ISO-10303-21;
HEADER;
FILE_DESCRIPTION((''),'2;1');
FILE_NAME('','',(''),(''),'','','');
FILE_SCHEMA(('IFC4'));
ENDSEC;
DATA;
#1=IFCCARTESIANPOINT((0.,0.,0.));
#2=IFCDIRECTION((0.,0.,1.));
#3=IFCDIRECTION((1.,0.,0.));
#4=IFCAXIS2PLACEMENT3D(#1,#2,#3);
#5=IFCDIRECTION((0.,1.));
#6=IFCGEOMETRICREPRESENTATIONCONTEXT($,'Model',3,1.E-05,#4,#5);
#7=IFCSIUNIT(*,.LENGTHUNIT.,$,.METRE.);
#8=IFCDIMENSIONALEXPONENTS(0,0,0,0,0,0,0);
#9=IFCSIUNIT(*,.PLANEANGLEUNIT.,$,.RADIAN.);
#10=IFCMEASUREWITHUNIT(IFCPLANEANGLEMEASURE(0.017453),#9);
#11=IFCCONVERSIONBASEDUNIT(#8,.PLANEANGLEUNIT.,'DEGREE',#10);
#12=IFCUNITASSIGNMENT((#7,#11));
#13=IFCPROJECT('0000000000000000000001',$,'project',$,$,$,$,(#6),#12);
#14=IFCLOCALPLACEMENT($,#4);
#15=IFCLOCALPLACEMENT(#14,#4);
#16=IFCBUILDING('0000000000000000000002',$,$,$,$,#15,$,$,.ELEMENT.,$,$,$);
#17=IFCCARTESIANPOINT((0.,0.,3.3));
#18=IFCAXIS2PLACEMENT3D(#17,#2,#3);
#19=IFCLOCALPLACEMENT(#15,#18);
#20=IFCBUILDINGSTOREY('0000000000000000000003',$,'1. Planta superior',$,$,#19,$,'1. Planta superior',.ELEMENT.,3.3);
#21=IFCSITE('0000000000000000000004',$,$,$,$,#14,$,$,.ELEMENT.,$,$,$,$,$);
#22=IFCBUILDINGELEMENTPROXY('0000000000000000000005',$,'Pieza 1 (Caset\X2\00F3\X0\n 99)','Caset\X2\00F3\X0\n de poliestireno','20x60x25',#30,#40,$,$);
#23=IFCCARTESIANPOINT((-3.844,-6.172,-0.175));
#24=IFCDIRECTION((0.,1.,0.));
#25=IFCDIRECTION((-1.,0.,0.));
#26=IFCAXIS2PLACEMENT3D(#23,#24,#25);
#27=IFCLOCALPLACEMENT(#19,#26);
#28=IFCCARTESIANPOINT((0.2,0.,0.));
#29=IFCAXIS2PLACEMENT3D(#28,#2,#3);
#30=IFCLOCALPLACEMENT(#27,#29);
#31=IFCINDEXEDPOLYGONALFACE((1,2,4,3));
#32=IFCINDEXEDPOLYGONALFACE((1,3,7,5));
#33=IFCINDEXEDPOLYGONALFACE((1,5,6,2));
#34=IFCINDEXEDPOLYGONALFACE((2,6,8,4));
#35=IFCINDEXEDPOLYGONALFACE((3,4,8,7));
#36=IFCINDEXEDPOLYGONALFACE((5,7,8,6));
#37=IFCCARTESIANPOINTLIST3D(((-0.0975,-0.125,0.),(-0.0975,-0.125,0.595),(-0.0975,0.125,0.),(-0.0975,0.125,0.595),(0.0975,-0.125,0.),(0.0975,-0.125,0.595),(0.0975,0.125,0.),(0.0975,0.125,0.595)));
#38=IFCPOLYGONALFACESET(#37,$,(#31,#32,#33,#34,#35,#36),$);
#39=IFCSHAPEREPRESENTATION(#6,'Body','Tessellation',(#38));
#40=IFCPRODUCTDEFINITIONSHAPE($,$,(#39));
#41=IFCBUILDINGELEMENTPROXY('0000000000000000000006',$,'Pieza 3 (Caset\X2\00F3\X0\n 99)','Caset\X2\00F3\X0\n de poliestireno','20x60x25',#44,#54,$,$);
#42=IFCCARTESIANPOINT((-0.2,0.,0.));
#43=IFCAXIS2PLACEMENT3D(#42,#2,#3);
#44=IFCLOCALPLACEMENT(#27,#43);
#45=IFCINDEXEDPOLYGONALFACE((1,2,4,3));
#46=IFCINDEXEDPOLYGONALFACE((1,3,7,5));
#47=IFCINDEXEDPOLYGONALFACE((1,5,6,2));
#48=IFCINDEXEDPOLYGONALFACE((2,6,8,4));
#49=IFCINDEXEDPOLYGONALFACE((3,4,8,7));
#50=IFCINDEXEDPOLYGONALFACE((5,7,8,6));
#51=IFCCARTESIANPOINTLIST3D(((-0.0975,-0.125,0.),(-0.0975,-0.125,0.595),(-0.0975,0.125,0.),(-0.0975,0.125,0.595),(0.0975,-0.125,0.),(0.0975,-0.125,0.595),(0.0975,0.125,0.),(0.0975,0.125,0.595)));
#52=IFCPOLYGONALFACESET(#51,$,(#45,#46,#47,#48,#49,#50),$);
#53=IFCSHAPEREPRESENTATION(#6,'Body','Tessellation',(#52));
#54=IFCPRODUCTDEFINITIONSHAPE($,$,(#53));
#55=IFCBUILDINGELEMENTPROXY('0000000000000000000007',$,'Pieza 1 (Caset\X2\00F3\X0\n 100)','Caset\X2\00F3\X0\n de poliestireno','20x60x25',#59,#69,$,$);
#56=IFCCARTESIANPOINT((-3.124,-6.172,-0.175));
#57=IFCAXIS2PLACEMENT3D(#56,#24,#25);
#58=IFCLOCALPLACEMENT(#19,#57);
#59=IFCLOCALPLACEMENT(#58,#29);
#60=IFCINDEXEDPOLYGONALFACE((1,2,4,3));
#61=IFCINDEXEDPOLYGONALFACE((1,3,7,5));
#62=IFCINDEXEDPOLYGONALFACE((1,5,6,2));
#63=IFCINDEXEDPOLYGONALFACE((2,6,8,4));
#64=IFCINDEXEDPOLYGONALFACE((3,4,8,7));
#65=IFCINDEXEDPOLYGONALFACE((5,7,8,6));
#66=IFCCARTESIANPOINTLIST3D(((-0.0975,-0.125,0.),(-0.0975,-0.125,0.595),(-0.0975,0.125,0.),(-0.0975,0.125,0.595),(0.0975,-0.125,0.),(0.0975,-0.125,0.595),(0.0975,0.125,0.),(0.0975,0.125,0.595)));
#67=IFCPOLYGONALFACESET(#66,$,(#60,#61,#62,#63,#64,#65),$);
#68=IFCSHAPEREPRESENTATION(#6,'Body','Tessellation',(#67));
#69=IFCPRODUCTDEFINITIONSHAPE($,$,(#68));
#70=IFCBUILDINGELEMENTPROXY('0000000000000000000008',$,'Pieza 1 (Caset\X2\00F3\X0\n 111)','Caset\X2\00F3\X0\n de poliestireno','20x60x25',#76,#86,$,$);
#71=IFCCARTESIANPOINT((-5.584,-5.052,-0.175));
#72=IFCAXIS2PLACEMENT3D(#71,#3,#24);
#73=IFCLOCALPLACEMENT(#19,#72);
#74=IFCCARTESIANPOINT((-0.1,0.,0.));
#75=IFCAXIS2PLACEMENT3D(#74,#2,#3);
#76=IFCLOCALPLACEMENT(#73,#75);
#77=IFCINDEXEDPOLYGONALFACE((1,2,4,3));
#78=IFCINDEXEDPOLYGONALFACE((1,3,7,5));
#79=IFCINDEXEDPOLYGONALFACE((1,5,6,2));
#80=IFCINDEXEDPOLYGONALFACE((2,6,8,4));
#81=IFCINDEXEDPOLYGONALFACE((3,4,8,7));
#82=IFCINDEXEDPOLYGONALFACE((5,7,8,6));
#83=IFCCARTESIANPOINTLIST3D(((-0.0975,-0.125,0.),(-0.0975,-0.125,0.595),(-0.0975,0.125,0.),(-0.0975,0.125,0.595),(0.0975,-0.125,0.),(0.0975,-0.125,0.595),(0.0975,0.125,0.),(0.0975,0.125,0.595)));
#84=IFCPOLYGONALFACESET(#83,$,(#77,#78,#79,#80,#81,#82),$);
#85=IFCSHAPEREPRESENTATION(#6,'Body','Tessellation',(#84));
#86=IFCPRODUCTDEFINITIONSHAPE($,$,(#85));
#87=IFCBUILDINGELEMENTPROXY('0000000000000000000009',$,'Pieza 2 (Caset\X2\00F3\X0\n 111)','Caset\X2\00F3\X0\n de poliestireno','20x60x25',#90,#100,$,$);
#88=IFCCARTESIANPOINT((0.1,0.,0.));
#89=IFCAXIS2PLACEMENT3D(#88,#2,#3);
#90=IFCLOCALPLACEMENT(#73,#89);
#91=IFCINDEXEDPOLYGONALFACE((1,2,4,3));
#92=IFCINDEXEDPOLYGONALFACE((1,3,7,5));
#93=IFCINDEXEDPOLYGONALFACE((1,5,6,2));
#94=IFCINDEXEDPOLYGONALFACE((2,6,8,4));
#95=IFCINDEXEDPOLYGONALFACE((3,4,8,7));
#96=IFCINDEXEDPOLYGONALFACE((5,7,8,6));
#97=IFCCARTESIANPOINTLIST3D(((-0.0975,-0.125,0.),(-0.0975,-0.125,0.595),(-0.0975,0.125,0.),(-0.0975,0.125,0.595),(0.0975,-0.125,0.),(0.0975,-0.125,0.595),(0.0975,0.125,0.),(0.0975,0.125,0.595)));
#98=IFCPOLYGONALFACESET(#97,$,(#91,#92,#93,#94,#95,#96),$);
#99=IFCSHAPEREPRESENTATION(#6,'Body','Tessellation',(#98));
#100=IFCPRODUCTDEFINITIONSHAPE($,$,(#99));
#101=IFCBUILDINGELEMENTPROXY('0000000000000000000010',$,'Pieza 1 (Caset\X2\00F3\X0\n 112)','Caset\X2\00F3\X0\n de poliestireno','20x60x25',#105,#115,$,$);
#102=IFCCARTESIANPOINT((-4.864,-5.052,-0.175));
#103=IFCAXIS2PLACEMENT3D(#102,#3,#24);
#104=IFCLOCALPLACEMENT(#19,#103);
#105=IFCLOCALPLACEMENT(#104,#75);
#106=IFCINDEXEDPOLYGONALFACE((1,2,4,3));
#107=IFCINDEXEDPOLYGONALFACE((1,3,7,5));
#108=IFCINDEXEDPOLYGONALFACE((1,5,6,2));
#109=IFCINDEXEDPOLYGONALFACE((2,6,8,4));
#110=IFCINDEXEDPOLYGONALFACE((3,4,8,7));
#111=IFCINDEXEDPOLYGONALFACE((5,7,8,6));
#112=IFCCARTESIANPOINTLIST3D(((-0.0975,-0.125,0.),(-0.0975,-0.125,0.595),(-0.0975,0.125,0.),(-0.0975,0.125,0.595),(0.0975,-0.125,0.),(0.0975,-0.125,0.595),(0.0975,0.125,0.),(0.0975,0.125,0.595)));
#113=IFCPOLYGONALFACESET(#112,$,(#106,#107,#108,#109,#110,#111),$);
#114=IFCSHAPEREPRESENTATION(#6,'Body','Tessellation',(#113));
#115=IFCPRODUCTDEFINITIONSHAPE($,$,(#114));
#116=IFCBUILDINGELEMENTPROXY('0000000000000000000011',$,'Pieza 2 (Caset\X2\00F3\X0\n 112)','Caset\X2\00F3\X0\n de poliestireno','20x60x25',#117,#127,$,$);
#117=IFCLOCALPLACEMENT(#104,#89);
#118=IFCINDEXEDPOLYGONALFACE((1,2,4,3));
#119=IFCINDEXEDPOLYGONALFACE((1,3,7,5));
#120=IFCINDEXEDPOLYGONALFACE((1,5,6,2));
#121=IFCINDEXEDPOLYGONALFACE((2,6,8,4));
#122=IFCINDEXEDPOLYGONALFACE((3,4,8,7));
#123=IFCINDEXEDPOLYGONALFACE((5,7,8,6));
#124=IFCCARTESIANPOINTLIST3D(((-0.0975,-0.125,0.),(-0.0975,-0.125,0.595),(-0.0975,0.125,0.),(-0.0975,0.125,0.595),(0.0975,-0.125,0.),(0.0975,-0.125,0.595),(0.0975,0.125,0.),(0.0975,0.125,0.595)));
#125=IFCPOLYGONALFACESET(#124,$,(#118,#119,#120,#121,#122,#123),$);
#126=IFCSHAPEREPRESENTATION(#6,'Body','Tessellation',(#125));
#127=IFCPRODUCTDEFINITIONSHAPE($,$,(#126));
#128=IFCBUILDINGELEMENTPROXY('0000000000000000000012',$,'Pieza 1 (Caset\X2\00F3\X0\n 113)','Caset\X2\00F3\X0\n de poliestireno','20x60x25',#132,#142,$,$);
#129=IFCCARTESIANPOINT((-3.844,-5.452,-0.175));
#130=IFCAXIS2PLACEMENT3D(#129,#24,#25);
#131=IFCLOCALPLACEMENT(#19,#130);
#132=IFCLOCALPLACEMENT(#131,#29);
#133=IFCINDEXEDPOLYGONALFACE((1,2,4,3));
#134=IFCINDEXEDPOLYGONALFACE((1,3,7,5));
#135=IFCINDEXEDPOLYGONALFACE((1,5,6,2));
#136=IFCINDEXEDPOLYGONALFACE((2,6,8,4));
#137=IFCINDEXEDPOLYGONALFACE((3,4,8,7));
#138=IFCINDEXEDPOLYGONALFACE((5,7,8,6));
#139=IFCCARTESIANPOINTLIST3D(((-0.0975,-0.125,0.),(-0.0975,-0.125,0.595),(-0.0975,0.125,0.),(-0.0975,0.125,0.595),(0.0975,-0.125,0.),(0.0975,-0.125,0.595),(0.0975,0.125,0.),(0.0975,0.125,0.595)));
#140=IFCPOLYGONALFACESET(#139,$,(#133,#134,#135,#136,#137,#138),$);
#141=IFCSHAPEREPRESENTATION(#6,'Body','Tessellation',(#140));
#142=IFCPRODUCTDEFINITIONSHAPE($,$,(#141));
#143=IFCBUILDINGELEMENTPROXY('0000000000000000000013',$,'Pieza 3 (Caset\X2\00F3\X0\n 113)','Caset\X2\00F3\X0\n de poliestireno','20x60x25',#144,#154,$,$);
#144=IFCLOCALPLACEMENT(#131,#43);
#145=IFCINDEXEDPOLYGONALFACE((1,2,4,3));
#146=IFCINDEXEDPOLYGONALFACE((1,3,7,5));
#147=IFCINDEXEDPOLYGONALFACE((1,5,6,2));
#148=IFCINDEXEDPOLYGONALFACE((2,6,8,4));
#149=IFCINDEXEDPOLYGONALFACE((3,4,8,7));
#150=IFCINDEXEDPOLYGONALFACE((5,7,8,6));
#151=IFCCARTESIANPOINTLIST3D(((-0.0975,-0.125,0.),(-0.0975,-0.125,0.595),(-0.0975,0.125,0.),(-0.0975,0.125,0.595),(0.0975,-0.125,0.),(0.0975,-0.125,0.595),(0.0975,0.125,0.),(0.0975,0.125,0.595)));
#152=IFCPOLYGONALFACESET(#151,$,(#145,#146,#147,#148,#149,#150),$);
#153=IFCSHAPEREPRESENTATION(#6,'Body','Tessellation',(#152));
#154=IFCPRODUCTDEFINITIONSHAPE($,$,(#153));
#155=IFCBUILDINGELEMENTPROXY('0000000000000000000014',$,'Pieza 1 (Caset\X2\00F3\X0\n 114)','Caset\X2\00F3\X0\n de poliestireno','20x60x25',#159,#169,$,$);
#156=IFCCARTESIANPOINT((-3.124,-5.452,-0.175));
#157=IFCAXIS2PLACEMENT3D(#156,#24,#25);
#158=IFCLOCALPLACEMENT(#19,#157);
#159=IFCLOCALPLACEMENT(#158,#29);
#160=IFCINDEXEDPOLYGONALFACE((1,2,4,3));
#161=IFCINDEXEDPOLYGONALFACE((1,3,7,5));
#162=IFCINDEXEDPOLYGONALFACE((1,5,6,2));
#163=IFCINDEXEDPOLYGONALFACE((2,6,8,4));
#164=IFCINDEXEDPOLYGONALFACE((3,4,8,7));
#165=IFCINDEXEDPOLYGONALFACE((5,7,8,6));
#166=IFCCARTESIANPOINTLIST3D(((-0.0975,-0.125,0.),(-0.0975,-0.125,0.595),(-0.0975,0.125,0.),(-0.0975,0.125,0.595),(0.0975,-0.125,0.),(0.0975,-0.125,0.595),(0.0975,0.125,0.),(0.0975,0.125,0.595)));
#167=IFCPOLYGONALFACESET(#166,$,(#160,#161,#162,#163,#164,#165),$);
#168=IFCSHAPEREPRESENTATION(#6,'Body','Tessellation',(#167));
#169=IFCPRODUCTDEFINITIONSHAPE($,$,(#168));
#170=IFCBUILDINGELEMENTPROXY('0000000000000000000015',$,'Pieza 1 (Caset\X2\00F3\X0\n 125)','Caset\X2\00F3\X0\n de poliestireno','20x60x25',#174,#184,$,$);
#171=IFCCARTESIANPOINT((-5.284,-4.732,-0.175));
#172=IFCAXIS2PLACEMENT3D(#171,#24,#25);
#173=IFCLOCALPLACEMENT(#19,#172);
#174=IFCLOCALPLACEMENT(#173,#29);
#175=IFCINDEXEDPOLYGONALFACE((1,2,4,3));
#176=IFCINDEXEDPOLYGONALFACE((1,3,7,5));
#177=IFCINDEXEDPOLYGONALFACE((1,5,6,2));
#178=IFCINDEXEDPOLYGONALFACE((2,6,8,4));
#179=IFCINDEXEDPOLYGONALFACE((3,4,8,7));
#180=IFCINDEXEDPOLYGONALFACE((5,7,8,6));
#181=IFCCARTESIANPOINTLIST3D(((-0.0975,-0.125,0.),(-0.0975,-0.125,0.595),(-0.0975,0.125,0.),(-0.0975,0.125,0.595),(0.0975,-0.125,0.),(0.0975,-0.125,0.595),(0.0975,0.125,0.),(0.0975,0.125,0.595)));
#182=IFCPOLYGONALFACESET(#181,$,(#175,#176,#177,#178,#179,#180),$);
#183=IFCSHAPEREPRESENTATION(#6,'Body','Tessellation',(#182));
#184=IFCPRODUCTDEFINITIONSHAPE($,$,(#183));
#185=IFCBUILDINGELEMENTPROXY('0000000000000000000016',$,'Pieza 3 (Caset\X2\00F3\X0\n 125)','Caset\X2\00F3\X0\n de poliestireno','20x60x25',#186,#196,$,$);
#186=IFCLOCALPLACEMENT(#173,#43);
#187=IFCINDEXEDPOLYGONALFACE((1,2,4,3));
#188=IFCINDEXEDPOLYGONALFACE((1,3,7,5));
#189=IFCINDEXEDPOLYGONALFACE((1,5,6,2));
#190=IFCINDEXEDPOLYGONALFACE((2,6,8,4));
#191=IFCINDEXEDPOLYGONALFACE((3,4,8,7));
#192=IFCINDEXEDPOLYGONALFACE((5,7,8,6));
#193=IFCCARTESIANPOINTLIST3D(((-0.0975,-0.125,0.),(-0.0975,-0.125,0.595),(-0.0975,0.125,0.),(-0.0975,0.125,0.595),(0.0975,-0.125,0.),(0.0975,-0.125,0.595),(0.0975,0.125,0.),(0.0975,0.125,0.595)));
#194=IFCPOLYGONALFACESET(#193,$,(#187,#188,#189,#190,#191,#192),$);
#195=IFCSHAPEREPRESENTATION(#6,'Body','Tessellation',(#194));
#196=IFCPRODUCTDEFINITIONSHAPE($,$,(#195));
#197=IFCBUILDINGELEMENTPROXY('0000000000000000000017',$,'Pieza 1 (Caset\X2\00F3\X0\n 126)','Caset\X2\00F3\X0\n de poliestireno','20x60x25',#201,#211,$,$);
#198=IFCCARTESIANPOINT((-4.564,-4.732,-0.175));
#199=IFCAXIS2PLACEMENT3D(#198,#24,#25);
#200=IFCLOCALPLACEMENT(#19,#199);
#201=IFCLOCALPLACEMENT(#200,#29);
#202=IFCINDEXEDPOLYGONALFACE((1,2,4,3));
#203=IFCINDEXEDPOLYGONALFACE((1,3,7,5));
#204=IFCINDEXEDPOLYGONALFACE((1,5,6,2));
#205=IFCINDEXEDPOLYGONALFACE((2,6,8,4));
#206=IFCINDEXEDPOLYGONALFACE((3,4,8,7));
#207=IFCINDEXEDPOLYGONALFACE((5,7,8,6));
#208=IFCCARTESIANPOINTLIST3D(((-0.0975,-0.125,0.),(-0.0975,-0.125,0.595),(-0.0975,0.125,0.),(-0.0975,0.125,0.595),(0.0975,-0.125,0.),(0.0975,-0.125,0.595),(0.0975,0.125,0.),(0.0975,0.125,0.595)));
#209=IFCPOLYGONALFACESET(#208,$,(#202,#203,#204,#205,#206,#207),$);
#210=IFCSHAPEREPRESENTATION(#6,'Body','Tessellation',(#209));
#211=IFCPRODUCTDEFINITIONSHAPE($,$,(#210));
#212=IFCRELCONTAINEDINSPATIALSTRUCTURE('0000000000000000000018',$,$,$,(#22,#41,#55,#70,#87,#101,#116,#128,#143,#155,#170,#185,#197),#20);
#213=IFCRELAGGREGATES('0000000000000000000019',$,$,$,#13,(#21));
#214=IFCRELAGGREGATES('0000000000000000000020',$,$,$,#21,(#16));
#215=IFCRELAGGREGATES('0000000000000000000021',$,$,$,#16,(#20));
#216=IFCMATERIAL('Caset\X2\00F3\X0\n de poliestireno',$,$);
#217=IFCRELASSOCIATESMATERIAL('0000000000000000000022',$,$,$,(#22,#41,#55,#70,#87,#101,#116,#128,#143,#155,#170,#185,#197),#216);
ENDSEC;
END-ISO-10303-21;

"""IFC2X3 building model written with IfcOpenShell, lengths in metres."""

from ifc_helpers import new_model, entity, si_unit, converted_unit, direction, frame, origin_with_axes, origin_2d_with_axis, place, context, project, spatial, rectangle, extrude, source, transform, mapped, material, element, save


model = new_model("IFC2X3")

# Units and contexts
model_context = context("Model", 3, precision=1e-05, world=origin_with_axes(), true_north=direction((0.0, 1.0)))
ifc_project = project(units=[si_unit("LENGTHUNIT", "METRE"), converted_unit("PLANEANGLEUNIT", "DEGREE", entity("IfcPlaneAngleMeasure", 0.017453), si_unit("PLANEANGLEUNIT", "RADIAN"), dimensions=[0, 0, 0, 0, 0, 0, 0])], contexts=[model_context])

# Site, building, storey
site_placement = place(None, origin_with_axes())
site = spatial("IfcSite", under=ifc_project, at=site_placement, CompositionType="ELEMENT")
building_placement = place(site_placement, origin_with_axes())
building = spatial("IfcBuilding", under=site, at=building_placement, CompositionType="ELEMENT")
storey_placement = place(building_placement, frame((0.0, 0.0, 3.3), z_axis=(0.0, 0.0, 1.0), x_axis=(1.0, 0.0, 0.0)))
storey = spatial("IfcBuildingStorey", under=building, at=storey_placement, Name="1. Planta superior", LongName="1. Planta superior", CompositionType="ELEMENT", Elevation=3.3)

# Building element proxies
ifc_material_1 = material(Name="Casetón de poliestireno")
shared_shape = source(origin_with_axes(), model_context, "Body", "SweptSolid", [
    extrude(rectangle(XDim=0.195, YDim=0.25, at=origin_2d_with_axis()), origin_with_axes(), (0.0, 0.0, 1.0), 0.595),
])
placement_1 = place(storey_placement, frame((-3.844, -6.172, -0.175), z_axis=(0.0, 1.0, 0.0), x_axis=(-1.0, 0.0, 0.0)))
for number, where, z_axis, x_axis, name in (
    (1, (0.2, 0.0, 0.0), (0.0, 0.0, 1.0), (1.0, 0.0, 0.0), "Pieza 1 (Casetón 99)"),
    (2, (-0.2, 0.0, 0.0), (0.0, 0.0, 1.0), (1.0, 0.0, 0.0), "Pieza 3 (Casetón 99)"),
):
    element("IfcBuildingElementProxy", number, at=place(placement_1, frame(where, z_axis=z_axis, x_axis=x_axis)), inside=storey, material=ifc_material_1, Name=name, Description="Casetón de poliestireno", ObjectType="20x60x25", context=model_context, shape_type="MappedRepresentation", body=[
        mapped(shared_shape, transform((0.0, 0.0, 0.0), x_axis=(1.0, 0.0, 0.0), y_axis=(0.0, 1.0, 0.0), z_axis=(0.0, 0.0, 1.0))),
    ])
placement_2 = place(storey_placement, frame((-3.124, -6.172, -0.175), z_axis=(0.0, 1.0, 0.0), x_axis=(-1.0, 0.0, 0.0)))
for number, where, z_axis, x_axis, name in (
    (3, (0.2, 0.0, 0.0), (0.0, 0.0, 1.0), (1.0, 0.0, 0.0), "Pieza 1 (Casetón 100)"),
):
    element("IfcBuildingElementProxy", number, at=place(placement_2, frame(where, z_axis=z_axis, x_axis=x_axis)), inside=storey, material=ifc_material_1, Name=name, Description="Casetón de poliestireno", ObjectType="20x60x25", context=model_context, shape_type="MappedRepresentation", body=[
        mapped(shared_shape, transform((0.0, 0.0, 0.0), x_axis=(1.0, 0.0, 0.0), y_axis=(0.0, 1.0, 0.0), z_axis=(0.0, 0.0, 1.0))),
    ])
placement_3 = place(storey_placement, frame((-5.584, -5.052, -0.175), z_axis=(1.0, 0.0, 0.0), x_axis=(0.0, 1.0, 0.0)))
for number, where, z_axis, x_axis, name in (
    (4, (-0.1, 0.0, 0.0), (0.0, 0.0, 1.0), (1.0, 0.0, 0.0), "Pieza 1 (Casetón 111)"),
    (5, (0.1, 0.0, 0.0), (0.0, 0.0, 1.0), (1.0, 0.0, 0.0), "Pieza 2 (Casetón 111)"),
):
    element("IfcBuildingElementProxy", number, at=place(placement_3, frame(where, z_axis=z_axis, x_axis=x_axis)), inside=storey, material=ifc_material_1, Name=name, Description="Casetón de poliestireno", ObjectType="20x60x25", context=model_context, shape_type="MappedRepresentation", body=[
        mapped(shared_shape, transform((0.0, 0.0, 0.0), x_axis=(1.0, 0.0, 0.0), y_axis=(0.0, 1.0, 0.0), z_axis=(0.0, 0.0, 1.0))),
    ])
placement_4 = place(storey_placement, frame((-4.864, -5.052, -0.175), z_axis=(1.0, 0.0, 0.0), x_axis=(0.0, 1.0, 0.0)))
for number, where, z_axis, x_axis, name in (
    (6, (-0.1, 0.0, 0.0), (0.0, 0.0, 1.0), (1.0, 0.0, 0.0), "Pieza 1 (Casetón 112)"),
    (7, (0.1, 0.0, 0.0), (0.0, 0.0, 1.0), (1.0, 0.0, 0.0), "Pieza 2 (Casetón 112)"),
):
    element("IfcBuildingElementProxy", number, at=place(placement_4, frame(where, z_axis=z_axis, x_axis=x_axis)), inside=storey, material=ifc_material_1, Name=name, Description="Casetón de poliestireno", ObjectType="20x60x25", context=model_context, shape_type="MappedRepresentation", body=[
        mapped(shared_shape, transform((0.0, 0.0, 0.0), x_axis=(1.0, 0.0, 0.0), y_axis=(0.0, 1.0, 0.0), z_axis=(0.0, 0.0, 1.0))),
    ])
placement_5 = place(storey_placement, frame((-3.844, -5.452, -0.175), z_axis=(0.0, 1.0, 0.0), x_axis=(-1.0, 0.0, 0.0)))
for number, where, z_axis, x_axis, name in (
    (8, (0.2, 0.0, 0.0), (0.0, 0.0, 1.0), (1.0, 0.0, 0.0), "Pieza 1 (Casetón 113)"),
    (9, (-0.2, 0.0, 0.0), (0.0, 0.0, 1.0), (1.0, 0.0, 0.0), "Pieza 3 (Casetón 113)"),
):
    element("IfcBuildingElementProxy", number, at=place(placement_5, frame(where, z_axis=z_axis, x_axis=x_axis)), inside=storey, material=ifc_material_1, Name=name, Description="Casetón de poliestireno", ObjectType="20x60x25", context=model_context, shape_type="MappedRepresentation", body=[
        mapped(shared_shape, transform((0.0, 0.0, 0.0), x_axis=(1.0, 0.0, 0.0), y_axis=(0.0, 1.0, 0.0), z_axis=(0.0, 0.0, 1.0))),
    ])
placement_6 = place(storey_placement, frame((-3.124, -5.452, -0.175), z_axis=(0.0, 1.0, 0.0), x_axis=(-1.0, 0.0, 0.0)))
for number, where, z_axis, x_axis, name in (
    (10, (0.2, 0.0, 0.0), (0.0, 0.0, 1.0), (1.0, 0.0, 0.0), "Pieza 1 (Casetón 114)"),
):
    element("IfcBuildingElementProxy", number, at=place(placement_6, frame(where, z_axis=z_axis, x_axis=x_axis)), inside=storey, material=ifc_material_1, Name=name, Description="Casetón de poliestireno", ObjectType="20x60x25", context=model_context, shape_type="MappedRepresentation", body=[
        mapped(shared_shape, transform((0.0, 0.0, 0.0), x_axis=(1.0, 0.0, 0.0), y_axis=(0.0, 1.0, 0.0), z_axis=(0.0, 0.0, 1.0))),
    ])
placement_7 = place(storey_placement, frame((-5.284, -4.732, -0.175), z_axis=(0.0, 1.0, 0.0), x_axis=(-1.0, 0.0, 0.0)))
for number, where, z_axis, x_axis, name in (
    (11, (0.2, 0.0, 0.0), (0.0, 0.0, 1.0), (1.0, 0.0, 0.0), "Pieza 1 (Casetón 125)"),
    (12, (-0.2, 0.0, 0.0), (0.0, 0.0, 1.0), (1.0, 0.0, 0.0), "Pieza 3 (Casetón 125)"),
):
    element("IfcBuildingElementProxy", number, at=place(placement_7, frame(where, z_axis=z_axis, x_axis=x_axis)), inside=storey, material=ifc_material_1, Name=name, Description="Casetón de poliestireno", ObjectType="20x60x25", context=model_context, shape_type="MappedRepresentation", body=[
        mapped(shared_shape, transform((0.0, 0.0, 0.0), x_axis=(1.0, 0.0, 0.0), y_axis=(0.0, 1.0, 0.0), z_axis=(0.0, 0.0, 1.0))),
    ])
placement_8 = place(storey_placement, frame((-4.564, -4.732, -0.175), z_axis=(0.0, 1.0, 0.0), x_axis=(-1.0, 0.0, 0.0)))
for number, where, z_axis, x_axis, name in (
    (13, (0.2, 0.0, 0.0), (0.0, 0.0, 1.0), (1.0, 0.0, 0.0), "Pieza 1 (Casetón 126)"),
):
    element("IfcBuildingElementProxy", number, at=place(placement_8, frame(where, z_axis=z_axis, x_axis=x_axis)), inside=storey, material=ifc_material_1, Name=name, Description="Casetón de poliestireno", ObjectType="20x60x25", context=model_context, shape_type="MappedRepresentation", body=[
        mapped(shared_shape, transform((0.0, 0.0, 0.0), x_axis=(1.0, 0.0, 0.0), y_axis=(0.0, 1.0, 0.0), z_axis=(0.0, 0.0, 1.0))),
    ])

save(model, "model.ifc")
